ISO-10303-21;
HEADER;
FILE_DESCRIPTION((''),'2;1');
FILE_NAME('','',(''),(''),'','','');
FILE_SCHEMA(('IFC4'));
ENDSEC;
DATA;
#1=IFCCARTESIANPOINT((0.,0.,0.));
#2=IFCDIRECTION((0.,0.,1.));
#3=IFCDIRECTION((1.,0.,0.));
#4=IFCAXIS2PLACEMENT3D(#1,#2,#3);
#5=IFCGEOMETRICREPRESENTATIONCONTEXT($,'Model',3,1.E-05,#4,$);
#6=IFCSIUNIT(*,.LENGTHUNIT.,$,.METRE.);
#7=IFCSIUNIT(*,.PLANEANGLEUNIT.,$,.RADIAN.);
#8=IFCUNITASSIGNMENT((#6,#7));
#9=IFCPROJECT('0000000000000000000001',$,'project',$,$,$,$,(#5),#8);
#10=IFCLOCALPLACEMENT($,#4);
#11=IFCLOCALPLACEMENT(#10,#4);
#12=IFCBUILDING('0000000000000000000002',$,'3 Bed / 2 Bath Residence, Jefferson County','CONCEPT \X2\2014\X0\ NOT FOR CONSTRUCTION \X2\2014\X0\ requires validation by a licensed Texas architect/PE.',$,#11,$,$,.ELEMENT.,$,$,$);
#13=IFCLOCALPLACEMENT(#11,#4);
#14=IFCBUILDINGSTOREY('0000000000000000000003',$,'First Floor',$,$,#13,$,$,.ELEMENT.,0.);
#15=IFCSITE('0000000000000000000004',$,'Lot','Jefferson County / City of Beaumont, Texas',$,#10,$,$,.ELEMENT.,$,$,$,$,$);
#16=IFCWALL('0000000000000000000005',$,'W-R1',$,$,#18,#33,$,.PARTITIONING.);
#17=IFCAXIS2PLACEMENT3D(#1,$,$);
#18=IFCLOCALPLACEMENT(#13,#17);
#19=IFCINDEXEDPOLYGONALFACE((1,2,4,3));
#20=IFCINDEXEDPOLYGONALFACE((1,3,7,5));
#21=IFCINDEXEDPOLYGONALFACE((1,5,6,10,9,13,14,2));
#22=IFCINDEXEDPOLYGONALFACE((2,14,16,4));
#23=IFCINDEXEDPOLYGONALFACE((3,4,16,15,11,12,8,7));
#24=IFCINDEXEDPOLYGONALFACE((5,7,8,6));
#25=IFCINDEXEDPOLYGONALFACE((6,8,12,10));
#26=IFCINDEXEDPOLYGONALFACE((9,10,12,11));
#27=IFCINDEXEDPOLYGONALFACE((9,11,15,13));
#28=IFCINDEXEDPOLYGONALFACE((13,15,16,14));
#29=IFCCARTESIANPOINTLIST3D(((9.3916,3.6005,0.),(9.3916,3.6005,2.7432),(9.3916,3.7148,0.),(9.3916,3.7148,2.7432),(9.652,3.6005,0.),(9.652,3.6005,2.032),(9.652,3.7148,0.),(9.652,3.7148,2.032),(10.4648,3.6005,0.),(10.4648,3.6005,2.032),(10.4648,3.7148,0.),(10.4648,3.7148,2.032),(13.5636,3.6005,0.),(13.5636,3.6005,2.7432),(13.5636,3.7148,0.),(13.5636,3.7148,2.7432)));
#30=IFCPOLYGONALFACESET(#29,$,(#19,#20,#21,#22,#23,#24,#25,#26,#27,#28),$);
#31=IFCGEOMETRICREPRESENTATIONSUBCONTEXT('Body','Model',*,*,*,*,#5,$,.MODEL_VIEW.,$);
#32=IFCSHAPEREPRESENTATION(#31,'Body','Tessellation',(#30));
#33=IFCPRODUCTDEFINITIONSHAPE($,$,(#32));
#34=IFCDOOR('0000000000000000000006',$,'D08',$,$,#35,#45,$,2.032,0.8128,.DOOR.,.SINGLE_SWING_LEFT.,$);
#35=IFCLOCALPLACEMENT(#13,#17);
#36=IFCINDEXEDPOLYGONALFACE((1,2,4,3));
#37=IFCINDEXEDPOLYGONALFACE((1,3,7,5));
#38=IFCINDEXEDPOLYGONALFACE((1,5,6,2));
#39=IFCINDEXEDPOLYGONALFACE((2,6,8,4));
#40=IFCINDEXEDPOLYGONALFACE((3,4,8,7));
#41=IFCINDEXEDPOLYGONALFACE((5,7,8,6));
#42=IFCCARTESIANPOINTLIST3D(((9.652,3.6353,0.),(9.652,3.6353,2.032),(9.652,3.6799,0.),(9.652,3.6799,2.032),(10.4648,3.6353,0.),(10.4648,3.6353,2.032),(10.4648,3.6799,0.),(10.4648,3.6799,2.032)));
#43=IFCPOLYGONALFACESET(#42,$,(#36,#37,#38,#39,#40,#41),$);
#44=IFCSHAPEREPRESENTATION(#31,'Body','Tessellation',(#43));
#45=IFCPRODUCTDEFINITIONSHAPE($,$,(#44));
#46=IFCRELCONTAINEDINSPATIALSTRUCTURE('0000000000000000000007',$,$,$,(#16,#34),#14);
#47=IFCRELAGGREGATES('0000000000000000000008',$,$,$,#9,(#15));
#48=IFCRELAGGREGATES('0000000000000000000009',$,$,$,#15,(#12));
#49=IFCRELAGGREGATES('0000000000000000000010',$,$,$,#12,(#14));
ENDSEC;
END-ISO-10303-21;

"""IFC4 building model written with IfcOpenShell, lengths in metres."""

from ifc_helpers import new_model, si_unit, frame, frame_2d, origin_with_axes, place, context, subcontext, project, spatial, rectangle, extrude, element, fill, save


model = new_model("IFC4")

# Units and contexts
model_context = context("Model", 3, precision=1e-05, world=origin_with_axes())
body_context = subcontext(model_context, "Body", "Model", "MODEL_VIEW")
ifc_project = project(units=[si_unit("LENGTHUNIT", "METRE"), si_unit("PLANEANGLEUNIT", "RADIAN")], contexts=[model_context])

# Site, building, storey
site_placement = place(None, origin_with_axes())
site = spatial("IfcSite", under=ifc_project, at=site_placement, Name="Lot", Description="Jefferson County / City of Beaumont, Texas", CompositionType="ELEMENT")
building_placement = place(site_placement, origin_with_axes())
building = spatial("IfcBuilding", under=site, at=building_placement, Name="3 Bed / 2 Bath Residence, Jefferson County", Description="CONCEPT — NOT FOR CONSTRUCTION — requires validation by a licensed Texas architect/PE.", CompositionType="ELEMENT")
storey_placement = place(building_placement, origin_with_axes())
storey = spatial("IfcBuildingStorey", under=building, at=storey_placement, Name="First Floor", CompositionType="ELEMENT", Elevation=0.0)

# Wall, opening, door
wall_1_placement = place(storey_placement, frame((9.3917, 3.6576, 0.0), z_axis=(0.0, 0.0, 1.0), x_axis=(1.0, 0.0, 0.0)))
wall_1 = element("IfcWall", 1, at=wall_1_placement, inside=storey, Name="W-R1", PredefinedType="PARTITIONING", context=body_context, shape_type="SweptSolid", body=[
    extrude(rectangle(XDim=4.1719, YDim=0.1143, at=frame_2d((2.086, 0.0), x_axis=(1.0, 0.0))), origin_with_axes(), (0.0, 0.0, 1.0), 2.7432),
])
opening_1_placement = place(wall_1_placement, frame((0.2603, 0.0, 0.0), z_axis=(0.0, 0.0, 1.0), x_axis=(1.0, 0.0, 0.0)))
opening_1 = element("IfcOpeningElement", 2, at=opening_1_placement, cuts=wall_1, PredefinedType="OPENING", context=body_context, shape_type="SweptSolid", body=[
    extrude(rectangle(XDim=0.8128, YDim=0.1448, at=frame_2d((0.4064, 0.0), x_axis=(1.0, 0.0))), origin_with_axes(), (0.0, 0.0, 1.0), 2.032),
])
door_1_placement = place(opening_1_placement, origin_with_axes())
door_1 = element("IfcDoor", 3, at=door_1_placement, inside=storey, Name="D08", OperationType="SINGLE_SWING_LEFT", OverallHeight=2.032, OverallWidth=0.8128, PredefinedType="DOOR", context=body_context, shape_type="SweptSolid", body=[
    extrude(rectangle(XDim=0.8128, YDim=0.0445, at=frame_2d((0.4064, 0.0), x_axis=(1.0, 0.0))), origin_with_axes(), (0.0, 0.0, 1.0), 2.032),
])
fill(opening_1, door_1)

save(model, "model.ifc")
